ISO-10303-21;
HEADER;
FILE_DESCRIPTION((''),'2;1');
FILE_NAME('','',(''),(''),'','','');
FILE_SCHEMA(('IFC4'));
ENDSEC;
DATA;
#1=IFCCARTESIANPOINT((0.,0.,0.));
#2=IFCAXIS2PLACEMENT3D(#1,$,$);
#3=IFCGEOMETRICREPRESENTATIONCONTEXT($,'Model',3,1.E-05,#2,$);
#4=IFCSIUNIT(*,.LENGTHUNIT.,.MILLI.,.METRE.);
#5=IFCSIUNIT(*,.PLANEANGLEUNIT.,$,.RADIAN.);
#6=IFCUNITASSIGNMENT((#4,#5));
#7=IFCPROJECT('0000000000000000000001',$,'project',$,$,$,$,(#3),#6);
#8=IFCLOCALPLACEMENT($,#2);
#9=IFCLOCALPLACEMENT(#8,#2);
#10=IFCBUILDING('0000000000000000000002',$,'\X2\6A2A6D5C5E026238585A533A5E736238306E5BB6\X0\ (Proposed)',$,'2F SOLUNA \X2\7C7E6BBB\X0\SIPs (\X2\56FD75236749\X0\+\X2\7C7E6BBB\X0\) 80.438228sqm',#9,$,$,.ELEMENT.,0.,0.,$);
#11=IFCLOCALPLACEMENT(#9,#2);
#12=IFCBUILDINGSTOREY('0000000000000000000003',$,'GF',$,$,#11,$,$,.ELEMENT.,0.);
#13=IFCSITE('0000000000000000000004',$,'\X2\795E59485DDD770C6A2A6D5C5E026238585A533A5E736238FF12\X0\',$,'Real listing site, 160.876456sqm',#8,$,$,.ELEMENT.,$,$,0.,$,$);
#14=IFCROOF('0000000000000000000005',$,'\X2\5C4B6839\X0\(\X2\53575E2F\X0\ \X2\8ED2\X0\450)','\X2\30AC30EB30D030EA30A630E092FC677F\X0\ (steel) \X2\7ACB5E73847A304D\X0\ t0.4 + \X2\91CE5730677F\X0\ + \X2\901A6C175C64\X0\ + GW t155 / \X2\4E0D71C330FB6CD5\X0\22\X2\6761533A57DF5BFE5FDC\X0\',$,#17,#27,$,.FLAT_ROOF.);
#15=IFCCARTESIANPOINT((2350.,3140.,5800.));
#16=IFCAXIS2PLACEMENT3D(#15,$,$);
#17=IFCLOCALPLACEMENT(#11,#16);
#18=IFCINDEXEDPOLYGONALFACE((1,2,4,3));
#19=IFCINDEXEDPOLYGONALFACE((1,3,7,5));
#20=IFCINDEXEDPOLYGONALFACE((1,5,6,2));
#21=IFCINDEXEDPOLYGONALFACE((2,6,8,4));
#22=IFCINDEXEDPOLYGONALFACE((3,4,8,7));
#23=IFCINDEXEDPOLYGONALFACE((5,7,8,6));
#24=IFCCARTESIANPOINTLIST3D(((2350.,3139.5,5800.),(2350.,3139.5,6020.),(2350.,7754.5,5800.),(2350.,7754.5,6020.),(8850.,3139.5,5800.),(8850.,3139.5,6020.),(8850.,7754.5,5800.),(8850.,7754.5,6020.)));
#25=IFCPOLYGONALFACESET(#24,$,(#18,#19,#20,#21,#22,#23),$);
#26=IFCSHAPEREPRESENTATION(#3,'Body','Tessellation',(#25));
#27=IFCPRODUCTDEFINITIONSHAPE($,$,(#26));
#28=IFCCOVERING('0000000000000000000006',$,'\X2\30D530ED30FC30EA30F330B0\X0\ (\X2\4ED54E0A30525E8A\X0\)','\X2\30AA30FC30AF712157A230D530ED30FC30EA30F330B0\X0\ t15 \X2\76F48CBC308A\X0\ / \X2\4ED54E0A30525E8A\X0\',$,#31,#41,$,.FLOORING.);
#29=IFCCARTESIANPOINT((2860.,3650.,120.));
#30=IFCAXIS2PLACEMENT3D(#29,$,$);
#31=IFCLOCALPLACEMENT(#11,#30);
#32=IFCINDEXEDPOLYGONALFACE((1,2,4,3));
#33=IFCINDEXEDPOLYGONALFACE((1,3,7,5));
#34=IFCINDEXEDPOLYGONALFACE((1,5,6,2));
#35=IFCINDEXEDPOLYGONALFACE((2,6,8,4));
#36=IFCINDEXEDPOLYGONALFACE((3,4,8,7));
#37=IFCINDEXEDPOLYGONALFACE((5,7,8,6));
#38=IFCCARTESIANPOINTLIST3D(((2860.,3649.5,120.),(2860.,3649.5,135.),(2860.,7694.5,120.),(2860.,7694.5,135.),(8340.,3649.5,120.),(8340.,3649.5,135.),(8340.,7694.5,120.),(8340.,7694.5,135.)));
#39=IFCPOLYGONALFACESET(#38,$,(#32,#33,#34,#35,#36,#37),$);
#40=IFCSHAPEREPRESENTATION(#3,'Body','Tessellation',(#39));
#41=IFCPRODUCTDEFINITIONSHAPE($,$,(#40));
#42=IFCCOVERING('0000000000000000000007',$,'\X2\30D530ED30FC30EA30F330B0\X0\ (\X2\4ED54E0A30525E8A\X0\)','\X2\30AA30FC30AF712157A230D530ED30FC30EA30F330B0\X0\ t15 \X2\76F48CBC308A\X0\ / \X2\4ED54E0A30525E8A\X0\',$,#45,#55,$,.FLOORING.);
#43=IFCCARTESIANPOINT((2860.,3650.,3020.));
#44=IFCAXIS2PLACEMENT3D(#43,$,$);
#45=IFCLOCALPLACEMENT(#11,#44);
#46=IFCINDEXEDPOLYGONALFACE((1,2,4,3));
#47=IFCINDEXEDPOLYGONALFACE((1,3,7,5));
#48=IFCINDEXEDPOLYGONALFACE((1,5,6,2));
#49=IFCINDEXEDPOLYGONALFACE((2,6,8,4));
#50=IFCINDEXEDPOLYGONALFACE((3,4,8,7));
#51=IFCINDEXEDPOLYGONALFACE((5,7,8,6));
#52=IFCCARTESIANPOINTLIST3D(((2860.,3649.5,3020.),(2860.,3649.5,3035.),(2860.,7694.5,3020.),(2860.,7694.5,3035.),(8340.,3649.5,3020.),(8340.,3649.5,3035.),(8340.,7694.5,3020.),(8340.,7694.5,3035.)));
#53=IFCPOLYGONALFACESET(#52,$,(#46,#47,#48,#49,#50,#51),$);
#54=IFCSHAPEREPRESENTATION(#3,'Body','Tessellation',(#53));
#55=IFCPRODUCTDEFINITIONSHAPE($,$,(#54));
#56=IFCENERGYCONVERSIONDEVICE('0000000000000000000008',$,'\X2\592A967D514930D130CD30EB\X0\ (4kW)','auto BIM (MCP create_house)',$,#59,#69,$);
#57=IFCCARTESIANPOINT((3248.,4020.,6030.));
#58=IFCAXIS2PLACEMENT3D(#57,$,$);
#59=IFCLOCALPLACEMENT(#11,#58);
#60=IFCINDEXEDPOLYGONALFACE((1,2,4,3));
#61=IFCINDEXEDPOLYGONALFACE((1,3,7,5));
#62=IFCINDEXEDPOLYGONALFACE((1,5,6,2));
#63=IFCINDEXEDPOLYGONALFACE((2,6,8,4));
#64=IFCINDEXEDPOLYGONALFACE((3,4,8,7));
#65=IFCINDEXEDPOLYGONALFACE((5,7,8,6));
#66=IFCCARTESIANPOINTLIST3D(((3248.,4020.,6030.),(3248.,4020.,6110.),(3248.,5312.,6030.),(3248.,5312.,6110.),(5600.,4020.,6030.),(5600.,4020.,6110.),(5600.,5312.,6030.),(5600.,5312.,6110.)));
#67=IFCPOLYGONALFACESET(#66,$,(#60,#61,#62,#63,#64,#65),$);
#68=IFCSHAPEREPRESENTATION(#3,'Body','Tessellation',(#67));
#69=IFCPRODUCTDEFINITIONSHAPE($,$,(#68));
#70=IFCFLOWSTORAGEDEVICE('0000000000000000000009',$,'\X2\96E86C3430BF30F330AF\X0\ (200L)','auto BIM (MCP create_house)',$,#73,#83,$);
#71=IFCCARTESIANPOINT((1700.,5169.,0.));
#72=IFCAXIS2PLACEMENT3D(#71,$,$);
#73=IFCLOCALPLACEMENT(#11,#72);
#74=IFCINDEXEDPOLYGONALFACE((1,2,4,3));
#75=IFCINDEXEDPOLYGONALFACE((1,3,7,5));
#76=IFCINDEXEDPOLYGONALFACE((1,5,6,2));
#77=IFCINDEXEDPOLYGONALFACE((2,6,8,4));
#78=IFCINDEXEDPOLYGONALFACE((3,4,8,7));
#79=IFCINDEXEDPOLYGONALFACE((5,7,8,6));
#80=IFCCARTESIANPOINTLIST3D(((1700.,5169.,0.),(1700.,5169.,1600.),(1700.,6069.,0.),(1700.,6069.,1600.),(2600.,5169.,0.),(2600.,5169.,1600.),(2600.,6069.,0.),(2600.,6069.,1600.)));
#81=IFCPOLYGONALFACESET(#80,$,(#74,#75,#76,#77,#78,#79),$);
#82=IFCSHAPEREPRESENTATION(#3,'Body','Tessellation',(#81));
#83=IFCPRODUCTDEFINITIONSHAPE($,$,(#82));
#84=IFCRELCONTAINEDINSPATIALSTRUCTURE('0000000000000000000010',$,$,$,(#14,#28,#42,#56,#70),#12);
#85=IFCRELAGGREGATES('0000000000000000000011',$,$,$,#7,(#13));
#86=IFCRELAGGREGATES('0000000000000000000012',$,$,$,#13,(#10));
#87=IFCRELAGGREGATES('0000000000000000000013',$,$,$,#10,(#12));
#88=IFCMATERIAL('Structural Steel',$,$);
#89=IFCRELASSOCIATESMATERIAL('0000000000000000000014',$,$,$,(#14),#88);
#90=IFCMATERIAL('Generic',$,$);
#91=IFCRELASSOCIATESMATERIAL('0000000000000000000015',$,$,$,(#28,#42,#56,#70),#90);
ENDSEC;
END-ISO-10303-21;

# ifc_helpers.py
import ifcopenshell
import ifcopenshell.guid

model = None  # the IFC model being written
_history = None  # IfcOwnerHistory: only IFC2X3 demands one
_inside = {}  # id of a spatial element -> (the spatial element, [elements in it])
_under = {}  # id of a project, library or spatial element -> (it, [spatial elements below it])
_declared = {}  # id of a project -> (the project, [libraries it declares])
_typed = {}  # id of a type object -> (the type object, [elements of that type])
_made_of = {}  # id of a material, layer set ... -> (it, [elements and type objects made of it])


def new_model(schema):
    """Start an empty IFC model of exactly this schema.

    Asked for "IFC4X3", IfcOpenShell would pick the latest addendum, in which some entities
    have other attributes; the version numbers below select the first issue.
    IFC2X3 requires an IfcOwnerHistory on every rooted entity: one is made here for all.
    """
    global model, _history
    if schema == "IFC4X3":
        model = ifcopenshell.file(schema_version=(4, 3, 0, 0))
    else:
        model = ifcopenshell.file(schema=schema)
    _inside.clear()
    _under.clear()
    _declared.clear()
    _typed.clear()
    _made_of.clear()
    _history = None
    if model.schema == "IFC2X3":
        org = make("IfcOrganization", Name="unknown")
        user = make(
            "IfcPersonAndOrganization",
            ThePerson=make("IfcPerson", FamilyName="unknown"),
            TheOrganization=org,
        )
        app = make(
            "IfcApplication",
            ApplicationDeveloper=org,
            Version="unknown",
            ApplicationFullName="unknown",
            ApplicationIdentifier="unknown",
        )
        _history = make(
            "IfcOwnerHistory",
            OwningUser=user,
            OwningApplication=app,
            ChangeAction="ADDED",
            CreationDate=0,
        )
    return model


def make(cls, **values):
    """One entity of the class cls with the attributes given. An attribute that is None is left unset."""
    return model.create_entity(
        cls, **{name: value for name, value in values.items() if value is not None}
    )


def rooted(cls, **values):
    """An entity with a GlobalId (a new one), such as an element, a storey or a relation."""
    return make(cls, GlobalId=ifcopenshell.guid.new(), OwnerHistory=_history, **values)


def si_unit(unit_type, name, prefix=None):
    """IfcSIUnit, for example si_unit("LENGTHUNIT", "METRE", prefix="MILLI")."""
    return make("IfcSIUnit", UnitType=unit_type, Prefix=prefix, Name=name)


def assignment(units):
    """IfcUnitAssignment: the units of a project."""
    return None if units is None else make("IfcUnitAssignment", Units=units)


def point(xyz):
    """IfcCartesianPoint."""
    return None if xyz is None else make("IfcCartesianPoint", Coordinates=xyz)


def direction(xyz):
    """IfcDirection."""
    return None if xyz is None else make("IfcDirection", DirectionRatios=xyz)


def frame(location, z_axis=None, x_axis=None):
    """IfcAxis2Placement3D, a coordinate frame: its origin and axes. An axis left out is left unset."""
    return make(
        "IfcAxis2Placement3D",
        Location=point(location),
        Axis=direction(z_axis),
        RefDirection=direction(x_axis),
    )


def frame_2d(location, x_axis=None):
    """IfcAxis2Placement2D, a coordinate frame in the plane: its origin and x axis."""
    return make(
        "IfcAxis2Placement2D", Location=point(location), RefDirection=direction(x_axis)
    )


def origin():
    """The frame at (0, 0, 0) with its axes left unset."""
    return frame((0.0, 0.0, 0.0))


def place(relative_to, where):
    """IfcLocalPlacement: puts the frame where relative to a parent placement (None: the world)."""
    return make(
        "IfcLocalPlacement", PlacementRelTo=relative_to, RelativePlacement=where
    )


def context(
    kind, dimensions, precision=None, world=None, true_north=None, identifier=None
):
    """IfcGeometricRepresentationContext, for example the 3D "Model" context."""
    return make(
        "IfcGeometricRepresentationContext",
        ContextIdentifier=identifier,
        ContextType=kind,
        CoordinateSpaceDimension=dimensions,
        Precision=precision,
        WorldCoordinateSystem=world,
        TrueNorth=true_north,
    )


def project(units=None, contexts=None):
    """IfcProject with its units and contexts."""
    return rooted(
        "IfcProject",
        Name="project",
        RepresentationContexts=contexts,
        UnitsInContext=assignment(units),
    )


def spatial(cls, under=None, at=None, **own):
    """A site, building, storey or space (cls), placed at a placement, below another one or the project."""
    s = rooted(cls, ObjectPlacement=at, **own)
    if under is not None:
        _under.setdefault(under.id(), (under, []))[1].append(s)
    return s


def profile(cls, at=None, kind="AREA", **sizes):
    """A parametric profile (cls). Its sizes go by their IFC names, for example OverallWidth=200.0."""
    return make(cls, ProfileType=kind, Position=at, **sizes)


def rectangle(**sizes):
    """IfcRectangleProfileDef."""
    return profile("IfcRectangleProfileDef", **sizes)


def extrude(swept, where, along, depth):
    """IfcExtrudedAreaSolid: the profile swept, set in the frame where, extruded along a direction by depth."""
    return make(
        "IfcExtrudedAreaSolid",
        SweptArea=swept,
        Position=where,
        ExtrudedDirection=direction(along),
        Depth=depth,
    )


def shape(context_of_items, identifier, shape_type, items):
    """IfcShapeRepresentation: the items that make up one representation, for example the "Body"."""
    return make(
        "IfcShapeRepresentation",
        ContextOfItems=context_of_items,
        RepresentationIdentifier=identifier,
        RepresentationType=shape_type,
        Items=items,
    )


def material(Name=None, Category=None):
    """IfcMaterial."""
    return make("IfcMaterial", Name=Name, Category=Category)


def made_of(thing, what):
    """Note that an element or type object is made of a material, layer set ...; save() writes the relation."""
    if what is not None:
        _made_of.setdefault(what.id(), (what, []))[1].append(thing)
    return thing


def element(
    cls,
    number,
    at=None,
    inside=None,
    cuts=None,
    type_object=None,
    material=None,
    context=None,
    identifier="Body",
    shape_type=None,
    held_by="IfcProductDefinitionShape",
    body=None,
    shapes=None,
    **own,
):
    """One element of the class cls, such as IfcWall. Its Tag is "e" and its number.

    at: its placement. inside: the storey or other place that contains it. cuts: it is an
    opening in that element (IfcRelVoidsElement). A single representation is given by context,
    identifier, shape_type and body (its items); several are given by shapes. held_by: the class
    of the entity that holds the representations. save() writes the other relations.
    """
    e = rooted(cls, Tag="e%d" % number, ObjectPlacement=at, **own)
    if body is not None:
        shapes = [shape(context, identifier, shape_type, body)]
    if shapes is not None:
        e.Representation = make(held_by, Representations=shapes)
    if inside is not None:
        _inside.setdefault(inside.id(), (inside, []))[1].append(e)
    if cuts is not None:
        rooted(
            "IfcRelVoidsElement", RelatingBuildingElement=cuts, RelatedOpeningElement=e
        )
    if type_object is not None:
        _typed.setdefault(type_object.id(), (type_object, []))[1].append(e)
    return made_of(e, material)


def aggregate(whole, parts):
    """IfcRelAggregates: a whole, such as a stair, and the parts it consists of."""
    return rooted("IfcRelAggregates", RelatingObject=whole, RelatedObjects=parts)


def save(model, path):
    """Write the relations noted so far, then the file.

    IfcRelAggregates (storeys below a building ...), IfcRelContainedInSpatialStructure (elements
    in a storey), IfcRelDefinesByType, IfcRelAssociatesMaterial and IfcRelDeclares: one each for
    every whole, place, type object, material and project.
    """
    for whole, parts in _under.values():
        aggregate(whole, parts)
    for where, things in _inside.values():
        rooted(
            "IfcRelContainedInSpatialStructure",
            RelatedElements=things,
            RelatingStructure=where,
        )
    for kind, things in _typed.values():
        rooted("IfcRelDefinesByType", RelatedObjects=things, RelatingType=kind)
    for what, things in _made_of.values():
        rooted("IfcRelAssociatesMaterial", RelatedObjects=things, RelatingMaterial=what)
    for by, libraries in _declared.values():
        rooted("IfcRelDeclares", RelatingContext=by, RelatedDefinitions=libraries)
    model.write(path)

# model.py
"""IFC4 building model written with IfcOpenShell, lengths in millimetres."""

from ifc_helpers import new_model, si_unit, frame, frame_2d, origin, place, context, project, spatial, rectangle, extrude, material, element, save


model = new_model("IFC4")

# Units and contexts
model_context = context("Model", 3, precision=1e-05, world=origin())
ifc_project = project(units=[si_unit("LENGTHUNIT", "METRE", prefix="MILLI"), si_unit("PLANEANGLEUNIT", "RADIAN")], contexts=[model_context])

# Site, building, storey
site_placement = place(None, origin())
site = spatial("IfcSite", under=ifc_project, at=site_placement, Name="神奈川県横浜市戸塚区平戸２", ObjectType="Real listing site, 160.876456sqm", CompositionType="ELEMENT", RefElevation=0.0)
building_placement = place(site_placement, origin())
building = spatial("IfcBuilding", under=site, at=building_placement, Name="横浜市戸塚区平戸の家 (Proposed)", ObjectType="2F SOLUNA 籾殻SIPs (国産杉+籾殻) 80.438228sqm", CompositionType="ELEMENT", ElevationOfRefHeight=0.0, ElevationOfTerrain=0.0)
storey_placement = place(building_placement, origin())
storey = spatial("IfcBuildingStorey", under=building, at=storey_placement, Name="GF", CompositionType="ELEMENT", Elevation=0.0)

# Roof
ifc_material_1 = material(Name="Structural Steel")
for number, where, name in (
    (1, (2350.0, 3140.0, 5800.0), "屋根(南帯 軒450)"),
):
    element("IfcRoof", number, at=place(storey_placement, frame(where)), inside=storey, material=ifc_material_1, Name=name, Description="ガルバリウム鋼板 (steel) 立平葺き t0.4 + 野地板 + 通気層 + GW t155 / 不燃・法22条区域対応", PredefinedType="FLAT_ROOF", context=model_context, shape_type="SweptSolid", body=[
        extrude(rectangle(XDim=6500.0, YDim=4615.0, at=frame_2d((3250.0, 2307.0))), frame((2350.0, 3140.0, 5800.0)), (0.0, 0.0, 1.0), 220.0),
    ])

# Coverings
ifc_material_2 = material(Name="Generic")
covering_1_placement = place(storey_placement, frame((2860.0, 3650.0, 120.0)))
element("IfcCovering", 2, at=covering_1_placement, inside=storey, material=ifc_material_2, Name="フローリング (仕上げ床)", Description="オーク無垢フローリング t15 直貼り / 仕上げ床", PredefinedType="FLOORING", context=model_context, shape_type="SweptSolid", body=[
    extrude(rectangle(XDim=5480.0, YDim=4045.0, at=frame_2d((2740.0, 2022.0))), frame((2860.0, 3650.0, 120.0)), (0.0, 0.0, 1.0), 15.0),
])
covering_2_placement = place(storey_placement, frame((2860.0, 3650.0, 3020.0)))
element("IfcCovering", 3, at=covering_2_placement, inside=storey, material=ifc_material_2, Name="フローリング (仕上げ床)", Description="オーク無垢フローリング t15 直貼り / 仕上げ床", PredefinedType="FLOORING", context=model_context, shape_type="SweptSolid", body=[
    extrude(rectangle(XDim=5480.0, YDim=4045.0, at=frame_2d((2740.0, 2022.0))), frame((2860.0, 3650.0, 3020.0)), (0.0, 0.0, 1.0), 15.0),
])

# Energy conversion device
energy_conversion_device_placement = place(storey_placement, frame((3248.0, 4020.0, 6030.0)))
element("IfcEnergyConversionDevice", 4, at=energy_conversion_device_placement, inside=storey, material=ifc_material_2, Name="太陽光パネル (4kW)", Description="auto BIM (MCP create_house)", context=model_context, shape_type="SweptSolid", body=[
    extrude(rectangle(XDim=2352.0, YDim=1292.0, at=frame_2d((1176.0, 646.0))), frame((3248.0, 4020.0, 6030.0)), (0.0, 0.0, 1.0), 80.0),
])

# Flow storage device
flow_storage_device_placement = place(storey_placement, frame((1700.0, 5169.0, 0.0)))
element("IfcFlowStorageDevice", 5, at=flow_storage_device_placement, inside=storey, material=ifc_material_2, Name="雨水タンク (200L)", Description="auto BIM (MCP create_house)", context=model_context, shape_type="SweptSolid", body=[
    extrude(rectangle(XDim=900.0, YDim=900.0, at=frame_2d((450.0, 450.0))), frame((1700.0, 5169.0, 0.0)), (0.0, 0.0, 1.0), 1600.0),
])

save(model, "model.ifc")
